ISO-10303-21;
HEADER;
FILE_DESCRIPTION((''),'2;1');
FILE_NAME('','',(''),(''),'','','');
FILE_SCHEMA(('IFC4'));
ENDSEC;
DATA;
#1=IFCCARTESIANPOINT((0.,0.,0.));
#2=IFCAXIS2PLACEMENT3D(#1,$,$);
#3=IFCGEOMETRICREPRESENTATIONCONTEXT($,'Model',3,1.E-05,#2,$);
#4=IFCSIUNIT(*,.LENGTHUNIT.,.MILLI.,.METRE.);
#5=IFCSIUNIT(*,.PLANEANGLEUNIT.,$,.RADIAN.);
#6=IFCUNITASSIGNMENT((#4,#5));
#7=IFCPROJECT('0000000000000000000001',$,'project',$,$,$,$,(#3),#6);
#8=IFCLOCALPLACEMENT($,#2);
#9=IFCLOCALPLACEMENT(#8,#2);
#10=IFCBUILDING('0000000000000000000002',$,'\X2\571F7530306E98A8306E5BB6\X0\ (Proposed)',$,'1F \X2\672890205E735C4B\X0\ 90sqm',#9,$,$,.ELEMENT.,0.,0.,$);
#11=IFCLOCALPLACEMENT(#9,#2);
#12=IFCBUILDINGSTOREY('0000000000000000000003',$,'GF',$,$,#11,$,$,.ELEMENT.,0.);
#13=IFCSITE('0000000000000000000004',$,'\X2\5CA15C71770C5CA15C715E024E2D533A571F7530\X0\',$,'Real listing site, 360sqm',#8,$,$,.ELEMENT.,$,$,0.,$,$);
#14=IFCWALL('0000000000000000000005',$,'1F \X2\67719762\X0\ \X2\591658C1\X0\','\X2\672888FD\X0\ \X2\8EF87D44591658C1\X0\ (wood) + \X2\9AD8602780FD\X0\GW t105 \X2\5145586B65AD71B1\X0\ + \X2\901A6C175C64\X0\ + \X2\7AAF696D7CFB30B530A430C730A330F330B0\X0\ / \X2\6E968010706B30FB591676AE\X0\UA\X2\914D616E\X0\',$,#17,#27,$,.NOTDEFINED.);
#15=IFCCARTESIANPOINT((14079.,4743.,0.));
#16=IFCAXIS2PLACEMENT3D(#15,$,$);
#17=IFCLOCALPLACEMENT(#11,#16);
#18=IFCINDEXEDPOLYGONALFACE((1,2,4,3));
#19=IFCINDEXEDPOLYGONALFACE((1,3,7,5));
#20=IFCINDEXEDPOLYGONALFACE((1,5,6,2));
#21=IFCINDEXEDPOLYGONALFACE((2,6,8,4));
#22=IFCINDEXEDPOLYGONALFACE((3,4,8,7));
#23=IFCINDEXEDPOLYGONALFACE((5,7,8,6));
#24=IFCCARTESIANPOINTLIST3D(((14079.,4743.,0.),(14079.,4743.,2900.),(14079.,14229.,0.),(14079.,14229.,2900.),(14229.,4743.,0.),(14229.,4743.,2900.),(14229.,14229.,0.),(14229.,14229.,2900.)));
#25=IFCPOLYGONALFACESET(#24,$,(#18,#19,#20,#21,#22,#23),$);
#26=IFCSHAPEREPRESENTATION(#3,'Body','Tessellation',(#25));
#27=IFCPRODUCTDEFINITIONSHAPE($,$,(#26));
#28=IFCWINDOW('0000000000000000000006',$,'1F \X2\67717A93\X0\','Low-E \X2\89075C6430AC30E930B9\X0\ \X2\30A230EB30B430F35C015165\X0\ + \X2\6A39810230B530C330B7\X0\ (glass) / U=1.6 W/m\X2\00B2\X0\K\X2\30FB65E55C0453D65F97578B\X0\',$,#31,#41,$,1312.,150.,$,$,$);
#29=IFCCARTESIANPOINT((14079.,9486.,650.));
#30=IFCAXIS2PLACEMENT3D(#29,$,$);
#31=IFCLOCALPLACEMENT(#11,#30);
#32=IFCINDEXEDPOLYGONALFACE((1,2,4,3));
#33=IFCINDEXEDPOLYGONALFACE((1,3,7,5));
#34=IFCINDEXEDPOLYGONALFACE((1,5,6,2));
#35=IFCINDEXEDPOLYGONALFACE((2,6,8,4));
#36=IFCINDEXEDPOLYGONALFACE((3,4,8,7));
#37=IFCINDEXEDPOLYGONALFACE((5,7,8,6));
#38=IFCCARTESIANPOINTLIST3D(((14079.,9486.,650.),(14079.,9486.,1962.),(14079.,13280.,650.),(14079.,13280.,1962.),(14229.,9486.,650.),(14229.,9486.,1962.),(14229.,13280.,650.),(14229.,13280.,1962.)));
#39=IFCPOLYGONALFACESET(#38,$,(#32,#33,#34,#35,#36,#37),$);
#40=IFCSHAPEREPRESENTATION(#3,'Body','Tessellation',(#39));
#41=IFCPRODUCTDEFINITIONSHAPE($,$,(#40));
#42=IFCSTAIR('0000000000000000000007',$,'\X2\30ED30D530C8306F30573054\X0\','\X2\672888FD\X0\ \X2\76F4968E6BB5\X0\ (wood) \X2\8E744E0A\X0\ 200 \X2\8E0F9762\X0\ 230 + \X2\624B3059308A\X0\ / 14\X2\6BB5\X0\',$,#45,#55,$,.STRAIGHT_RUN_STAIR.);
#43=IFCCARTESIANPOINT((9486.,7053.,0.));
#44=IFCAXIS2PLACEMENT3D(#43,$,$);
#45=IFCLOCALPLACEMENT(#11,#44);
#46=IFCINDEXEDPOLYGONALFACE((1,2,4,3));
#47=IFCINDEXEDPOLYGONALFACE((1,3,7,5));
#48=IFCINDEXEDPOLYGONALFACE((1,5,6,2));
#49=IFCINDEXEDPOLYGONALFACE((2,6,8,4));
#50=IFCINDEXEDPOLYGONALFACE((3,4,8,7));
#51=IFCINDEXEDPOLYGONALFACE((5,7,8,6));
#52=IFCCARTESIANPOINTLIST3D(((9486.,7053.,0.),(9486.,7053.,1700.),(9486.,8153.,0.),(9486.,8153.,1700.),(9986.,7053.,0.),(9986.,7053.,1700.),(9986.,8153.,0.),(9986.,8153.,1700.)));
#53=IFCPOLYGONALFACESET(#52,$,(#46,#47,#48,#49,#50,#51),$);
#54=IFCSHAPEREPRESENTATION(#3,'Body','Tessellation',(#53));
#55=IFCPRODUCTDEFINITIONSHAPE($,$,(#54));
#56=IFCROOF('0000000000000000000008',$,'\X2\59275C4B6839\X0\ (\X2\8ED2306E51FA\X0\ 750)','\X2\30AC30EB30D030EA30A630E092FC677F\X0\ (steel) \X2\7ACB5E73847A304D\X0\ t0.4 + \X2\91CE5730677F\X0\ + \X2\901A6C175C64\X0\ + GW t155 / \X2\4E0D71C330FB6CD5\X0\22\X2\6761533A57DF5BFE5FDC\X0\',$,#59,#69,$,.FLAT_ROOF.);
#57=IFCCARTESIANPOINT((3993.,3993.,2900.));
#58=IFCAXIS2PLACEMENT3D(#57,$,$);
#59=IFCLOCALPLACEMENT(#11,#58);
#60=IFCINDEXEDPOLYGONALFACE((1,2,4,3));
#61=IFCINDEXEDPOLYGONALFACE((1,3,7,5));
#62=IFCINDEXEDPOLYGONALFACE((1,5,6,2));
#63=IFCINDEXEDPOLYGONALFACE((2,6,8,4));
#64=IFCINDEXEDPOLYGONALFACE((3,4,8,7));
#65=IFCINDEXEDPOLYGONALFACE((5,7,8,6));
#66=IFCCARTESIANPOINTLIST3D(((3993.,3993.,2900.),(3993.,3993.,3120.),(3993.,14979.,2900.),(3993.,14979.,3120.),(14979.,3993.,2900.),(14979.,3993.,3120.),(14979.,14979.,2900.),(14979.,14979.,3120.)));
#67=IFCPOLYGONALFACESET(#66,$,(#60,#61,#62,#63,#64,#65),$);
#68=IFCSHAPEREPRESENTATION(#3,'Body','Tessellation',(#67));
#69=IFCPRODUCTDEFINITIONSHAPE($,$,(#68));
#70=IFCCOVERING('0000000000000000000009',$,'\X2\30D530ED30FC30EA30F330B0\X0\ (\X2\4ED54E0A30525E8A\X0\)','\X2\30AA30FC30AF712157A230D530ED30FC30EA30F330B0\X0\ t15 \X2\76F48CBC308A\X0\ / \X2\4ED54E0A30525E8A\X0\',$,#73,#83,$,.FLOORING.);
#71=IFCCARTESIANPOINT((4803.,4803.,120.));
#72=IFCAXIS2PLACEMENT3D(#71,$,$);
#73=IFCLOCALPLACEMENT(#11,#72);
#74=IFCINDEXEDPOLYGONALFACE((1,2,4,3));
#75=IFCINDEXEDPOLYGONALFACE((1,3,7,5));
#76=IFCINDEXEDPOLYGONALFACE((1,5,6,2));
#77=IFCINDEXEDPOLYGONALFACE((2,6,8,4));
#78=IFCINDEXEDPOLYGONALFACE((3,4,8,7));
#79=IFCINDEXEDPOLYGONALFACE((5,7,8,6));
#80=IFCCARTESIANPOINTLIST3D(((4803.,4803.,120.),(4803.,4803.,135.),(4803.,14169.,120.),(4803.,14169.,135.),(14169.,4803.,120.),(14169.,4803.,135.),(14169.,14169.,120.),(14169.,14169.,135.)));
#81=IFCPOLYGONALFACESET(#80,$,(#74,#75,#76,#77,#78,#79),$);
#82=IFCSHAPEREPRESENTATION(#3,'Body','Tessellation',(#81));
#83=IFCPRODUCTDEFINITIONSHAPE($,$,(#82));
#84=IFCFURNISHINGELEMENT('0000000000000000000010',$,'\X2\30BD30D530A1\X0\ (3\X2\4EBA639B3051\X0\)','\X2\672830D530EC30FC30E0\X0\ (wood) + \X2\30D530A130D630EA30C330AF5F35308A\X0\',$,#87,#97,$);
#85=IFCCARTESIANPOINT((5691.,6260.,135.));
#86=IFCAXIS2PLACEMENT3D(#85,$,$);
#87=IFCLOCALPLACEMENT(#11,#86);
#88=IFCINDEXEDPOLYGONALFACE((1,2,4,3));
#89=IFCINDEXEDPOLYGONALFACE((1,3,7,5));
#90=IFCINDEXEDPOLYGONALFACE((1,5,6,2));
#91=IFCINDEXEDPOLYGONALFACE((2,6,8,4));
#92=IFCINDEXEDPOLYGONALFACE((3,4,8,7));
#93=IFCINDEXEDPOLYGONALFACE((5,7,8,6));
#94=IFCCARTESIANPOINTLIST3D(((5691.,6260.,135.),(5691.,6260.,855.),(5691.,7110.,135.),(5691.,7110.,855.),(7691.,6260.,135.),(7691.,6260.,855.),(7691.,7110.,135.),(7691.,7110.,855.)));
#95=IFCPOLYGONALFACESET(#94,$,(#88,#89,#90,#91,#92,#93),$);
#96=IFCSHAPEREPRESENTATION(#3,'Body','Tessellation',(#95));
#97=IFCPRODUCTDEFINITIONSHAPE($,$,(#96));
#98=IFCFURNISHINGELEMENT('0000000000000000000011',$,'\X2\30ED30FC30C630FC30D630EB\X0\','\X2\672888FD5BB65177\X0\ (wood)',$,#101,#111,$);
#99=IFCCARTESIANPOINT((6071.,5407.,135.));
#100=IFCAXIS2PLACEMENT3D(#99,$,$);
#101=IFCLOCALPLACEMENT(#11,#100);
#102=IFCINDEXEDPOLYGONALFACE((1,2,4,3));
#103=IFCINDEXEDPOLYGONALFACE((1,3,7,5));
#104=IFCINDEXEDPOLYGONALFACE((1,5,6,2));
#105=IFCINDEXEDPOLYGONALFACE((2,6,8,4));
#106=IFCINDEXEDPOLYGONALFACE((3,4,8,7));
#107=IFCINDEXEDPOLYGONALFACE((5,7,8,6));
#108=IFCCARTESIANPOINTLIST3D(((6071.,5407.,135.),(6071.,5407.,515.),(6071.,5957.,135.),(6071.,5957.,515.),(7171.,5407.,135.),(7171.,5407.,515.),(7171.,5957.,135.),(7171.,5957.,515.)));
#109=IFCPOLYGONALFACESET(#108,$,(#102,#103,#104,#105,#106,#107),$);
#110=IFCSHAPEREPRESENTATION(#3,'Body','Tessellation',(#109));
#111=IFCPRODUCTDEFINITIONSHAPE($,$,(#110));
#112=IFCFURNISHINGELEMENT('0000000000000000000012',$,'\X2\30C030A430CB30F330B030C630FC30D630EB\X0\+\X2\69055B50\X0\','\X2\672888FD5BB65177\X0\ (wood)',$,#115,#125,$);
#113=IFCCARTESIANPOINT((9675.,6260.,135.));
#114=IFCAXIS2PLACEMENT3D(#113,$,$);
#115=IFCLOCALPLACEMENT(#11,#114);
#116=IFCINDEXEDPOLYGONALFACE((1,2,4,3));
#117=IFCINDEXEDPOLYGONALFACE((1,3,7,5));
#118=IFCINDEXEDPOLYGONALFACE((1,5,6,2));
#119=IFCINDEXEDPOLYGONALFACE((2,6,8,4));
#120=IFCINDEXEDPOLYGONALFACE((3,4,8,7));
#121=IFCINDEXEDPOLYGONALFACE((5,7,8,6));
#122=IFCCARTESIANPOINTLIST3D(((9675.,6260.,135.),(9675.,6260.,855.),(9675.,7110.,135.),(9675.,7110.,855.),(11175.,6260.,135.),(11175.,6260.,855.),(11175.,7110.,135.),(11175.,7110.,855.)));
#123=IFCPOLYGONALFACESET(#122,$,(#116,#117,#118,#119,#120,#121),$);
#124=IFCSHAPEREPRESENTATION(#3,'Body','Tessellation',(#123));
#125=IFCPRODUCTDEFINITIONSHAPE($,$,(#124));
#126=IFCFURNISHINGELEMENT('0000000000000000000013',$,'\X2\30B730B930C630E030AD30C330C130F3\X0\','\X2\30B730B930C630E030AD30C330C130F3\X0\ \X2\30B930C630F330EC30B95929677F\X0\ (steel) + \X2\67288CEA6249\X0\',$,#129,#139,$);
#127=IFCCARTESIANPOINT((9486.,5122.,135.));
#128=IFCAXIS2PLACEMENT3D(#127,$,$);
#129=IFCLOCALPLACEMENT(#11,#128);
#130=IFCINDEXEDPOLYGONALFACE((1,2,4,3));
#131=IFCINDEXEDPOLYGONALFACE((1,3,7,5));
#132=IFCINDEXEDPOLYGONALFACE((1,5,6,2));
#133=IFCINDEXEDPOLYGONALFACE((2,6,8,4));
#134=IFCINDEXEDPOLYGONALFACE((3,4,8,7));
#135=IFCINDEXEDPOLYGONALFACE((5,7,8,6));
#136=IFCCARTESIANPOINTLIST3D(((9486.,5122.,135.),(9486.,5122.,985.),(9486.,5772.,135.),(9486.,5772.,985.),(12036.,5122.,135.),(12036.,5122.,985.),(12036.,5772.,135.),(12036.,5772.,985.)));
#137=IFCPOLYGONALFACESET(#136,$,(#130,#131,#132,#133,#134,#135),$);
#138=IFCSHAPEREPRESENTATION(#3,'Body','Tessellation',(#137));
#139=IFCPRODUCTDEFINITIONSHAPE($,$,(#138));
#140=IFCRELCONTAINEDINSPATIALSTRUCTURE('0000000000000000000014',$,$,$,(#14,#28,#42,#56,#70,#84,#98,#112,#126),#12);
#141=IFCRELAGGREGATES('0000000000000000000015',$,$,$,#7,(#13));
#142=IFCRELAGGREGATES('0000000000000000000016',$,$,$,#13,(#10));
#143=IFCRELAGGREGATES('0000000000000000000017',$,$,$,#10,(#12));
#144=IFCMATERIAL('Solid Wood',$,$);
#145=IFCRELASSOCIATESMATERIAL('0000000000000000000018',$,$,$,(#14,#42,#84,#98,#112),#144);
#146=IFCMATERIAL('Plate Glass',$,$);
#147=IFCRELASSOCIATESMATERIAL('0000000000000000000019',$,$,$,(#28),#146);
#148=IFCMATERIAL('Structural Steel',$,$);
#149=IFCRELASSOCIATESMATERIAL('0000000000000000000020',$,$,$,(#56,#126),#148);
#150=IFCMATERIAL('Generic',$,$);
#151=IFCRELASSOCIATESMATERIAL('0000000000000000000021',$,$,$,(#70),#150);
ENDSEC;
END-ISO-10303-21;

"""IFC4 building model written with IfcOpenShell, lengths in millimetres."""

from ifc_helpers import new_model, si_unit, frame, frame_2d, origin, place, context, project, spatial, rectangle, extrude, material, element, fill, save


model = new_model("IFC4")

# Units and contexts
model_context = context("Model", 3, precision=1e-05, world=origin())
ifc_project = project(units=[si_unit("LENGTHUNIT", "METRE", prefix="MILLI"), si_unit("PLANEANGLEUNIT", "RADIAN")], contexts=[model_context])

# Site, building, storey
site_placement = place(None, origin())
site = spatial("IfcSite", under=ifc_project, at=site_placement, Name="岡山県岡山市中区土田", ObjectType="Real listing site, 360sqm", CompositionType="ELEMENT", RefElevation=0.0)
building_placement = place(site_placement, origin())
building = spatial("IfcBuilding", under=site, at=building_placement, Name="土田の風の家 (Proposed)", ObjectType="1F 木造平屋 90sqm", CompositionType="ELEMENT", ElevationOfRefHeight=0.0, ElevationOfTerrain=0.0)
storey_placement = place(building_placement, origin())
storey = spatial("IfcBuildingStorey", under=building, at=storey_placement, Name="GF", CompositionType="ELEMENT", Elevation=0.0)

# Shared definitions
ifc_material_1 = material(Name="Solid Wood")

# Shared definitions
ifc_material_2 = material(Name="Plate Glass")

# Wall, opening, window
wall_1_placement = place(storey_placement, frame((14079.0, 4743.0, 0.0)))
wall_1 = element("IfcWall", 1, at=wall_1_placement, inside=storey, material=ifc_material_1, Name="1F 東面 外壁", Description="木製 軸組外壁 (wood) + 高性能GW t105 充填断熱 + 通気層 + 窯業系サイディング / 準耐火・外皮UA配慮", PredefinedType="NOTDEFINED", context=model_context, shape_type="SweptSolid", body=[
    extrude(rectangle(XDim=150.0, YDim=9486.0, at=frame_2d((75.0, 4743.0))), frame((14079.0, 4743.0, 0.0)), (0.0, 0.0, 1.0), 2900.0),
])
opening_1_placement = place(storey_placement, frame((14079.0, 9486.0, 650.0)))
opening_1 = element("IfcOpeningElement", 2, at=opening_1_placement, cuts=wall_1, PredefinedType="NOTDEFINED", context=model_context, shape_type="SweptSolid", body=[
    extrude(rectangle(XDim=150.0, YDim=3794.0, at=frame_2d((75.0, 1897.0))), frame((14079.0, 9486.0, 650.0)), (0.0, 0.0, 1.0), 1312.0),
])
window_1_placement = place(storey_placement, frame((14079.0, 9486.0, 650.0)))
window_1 = element("IfcWindow", 3, at=window_1_placement, inside=storey, material=ifc_material_2, Name="1F 東窓", Description="Low-E 複層ガラス アルゴン封入 + 樹脂サッシ (glass) / U=1.6 W/m²K・日射取得型", OverallHeight=1312.0, OverallWidth=150.0, context=model_context, shape_type="SweptSolid", body=[
    extrude(rectangle(XDim=150.0, YDim=3794.0, at=frame_2d((75.0, 1897.0))), frame((14079.0, 9486.0, 650.0)), (0.0, 0.0, 1.0), 1312.0),
])
fill(opening_1, window_1)

# Stair
stair_placement = place(storey_placement, frame((9486.0, 7053.0, 0.0)))
element("IfcStair", 4, at=stair_placement, inside=storey, material=ifc_material_1, Name="ロフトはしご", Description="木製 直階段 (wood) 蹴上 200 踏面 230 + 手すり / 14段", PredefinedType="STRAIGHT_RUN_STAIR", context=model_context, shape_type="SweptSolid", body=[
    extrude(rectangle(XDim=500.0, YDim=1100.0, at=frame_2d((250.0, 550.0))), frame((9486.0, 7053.0, 0.0)), (0.0, 0.0, 1.0), 1700.0),
])

# Roof
ifc_material_3 = material(Name="Structural Steel")
roof_placement = place(storey_placement, frame((3993.0, 3993.0, 2900.0)))
element("IfcRoof", 5, at=roof_placement, inside=storey, material=ifc_material_3, Name="大屋根 (軒の出 750)", Description="ガルバリウム鋼板 (steel) 立平葺き t0.4 + 野地板 + 通気層 + GW t155 / 不燃・法22条区域対応", PredefinedType="FLAT_ROOF", context=model_context, shape_type="SweptSolid", body=[
    extrude(rectangle(XDim=10986.0, YDim=10986.0, at=frame_2d((5493.0, 5493.0))), frame((3993.0, 3993.0, 2900.0)), (0.0, 0.0, 1.0), 220.0),
])

# Covering
ifc_material_4 = material(Name="Generic")
covering_placement = place(storey_placement, frame((4803.0, 4803.0, 120.0)))
element("IfcCovering", 6, at=covering_placement, inside=storey, material=ifc_material_4, Name="フローリング (仕上げ床)", Description="オーク無垢フローリング t15 直貼り / 仕上げ床", PredefinedType="FLOORING", context=model_context, shape_type="SweptSolid", body=[
    extrude(rectangle(XDim=9366.0, YDim=9366.0, at=frame_2d((4683.0, 4683.0))), frame((4803.0, 4803.0, 120.0)), (0.0, 0.0, 1.0), 15.0),
])

# Furnishing elements
furnishing_1_placement = place(storey_placement, frame((5691.0, 6260.0, 135.0)))
element("IfcFurnishingElement", 7, at=furnishing_1_placement, inside=storey, material=ifc_material_1, Name="ソファ (3人掛け)", Description="木フレーム (wood) + ファブリック張り", context=model_context, shape_type="SweptSolid", body=[
    extrude(rectangle(XDim=2000.0, YDim=850.0, at=frame_2d((1000.0, 425.0))), frame((5691.0, 6260.0, 135.0)), (0.0, 0.0, 1.0), 720.0),
])
furnishing_2_placement = place(storey_placement, frame((6071.0, 5407.0, 135.0)))
element("IfcFurnishingElement", 8, at=furnishing_2_placement, inside=storey, material=ifc_material_1, Name="ローテーブル", Description="木製家具 (wood)", context=model_context, shape_type="SweptSolid", body=[
    extrude(rectangle(XDim=1100.0, YDim=550.0, at=frame_2d((550.0, 275.0))), frame((6071.0, 5407.0, 135.0)), (0.0, 0.0, 1.0), 380.0),
])
furnishing_3_placement = place(storey_placement, frame((9675.0, 6260.0, 135.0)))
element("IfcFurnishingElement", 9, at=furnishing_3_placement, inside=storey, material=ifc_material_1, Name="ダイニングテーブル+椅子", Description="木製家具 (wood)", context=model_context, shape_type="SweptSolid", body=[
    extrude(rectangle(XDim=1500.0, YDim=850.0, at=frame_2d((750.0, 425.0))), frame((9675.0, 6260.0, 135.0)), (0.0, 0.0, 1.0), 720.0),
])
furnishing_4_placement = place(storey_placement, frame((9486.0, 5122.0, 135.0)))
element("IfcFurnishingElement", 10, at=furnishing_4_placement, inside=storey, material=ifc_material_3, Name="システムキッチン", Description="システムキッチン ステンレス天板 (steel) + 木質扉", context=model_context, shape_type="SweptSolid", body=[
    extrude(rectangle(XDim=2550.0, YDim=650.0, at=frame_2d((1275.0, 325.0))), frame((9486.0, 5122.0, 135.0)), (0.0, 0.0, 1.0), 850.0),
])

save(model, "model.ifc")
